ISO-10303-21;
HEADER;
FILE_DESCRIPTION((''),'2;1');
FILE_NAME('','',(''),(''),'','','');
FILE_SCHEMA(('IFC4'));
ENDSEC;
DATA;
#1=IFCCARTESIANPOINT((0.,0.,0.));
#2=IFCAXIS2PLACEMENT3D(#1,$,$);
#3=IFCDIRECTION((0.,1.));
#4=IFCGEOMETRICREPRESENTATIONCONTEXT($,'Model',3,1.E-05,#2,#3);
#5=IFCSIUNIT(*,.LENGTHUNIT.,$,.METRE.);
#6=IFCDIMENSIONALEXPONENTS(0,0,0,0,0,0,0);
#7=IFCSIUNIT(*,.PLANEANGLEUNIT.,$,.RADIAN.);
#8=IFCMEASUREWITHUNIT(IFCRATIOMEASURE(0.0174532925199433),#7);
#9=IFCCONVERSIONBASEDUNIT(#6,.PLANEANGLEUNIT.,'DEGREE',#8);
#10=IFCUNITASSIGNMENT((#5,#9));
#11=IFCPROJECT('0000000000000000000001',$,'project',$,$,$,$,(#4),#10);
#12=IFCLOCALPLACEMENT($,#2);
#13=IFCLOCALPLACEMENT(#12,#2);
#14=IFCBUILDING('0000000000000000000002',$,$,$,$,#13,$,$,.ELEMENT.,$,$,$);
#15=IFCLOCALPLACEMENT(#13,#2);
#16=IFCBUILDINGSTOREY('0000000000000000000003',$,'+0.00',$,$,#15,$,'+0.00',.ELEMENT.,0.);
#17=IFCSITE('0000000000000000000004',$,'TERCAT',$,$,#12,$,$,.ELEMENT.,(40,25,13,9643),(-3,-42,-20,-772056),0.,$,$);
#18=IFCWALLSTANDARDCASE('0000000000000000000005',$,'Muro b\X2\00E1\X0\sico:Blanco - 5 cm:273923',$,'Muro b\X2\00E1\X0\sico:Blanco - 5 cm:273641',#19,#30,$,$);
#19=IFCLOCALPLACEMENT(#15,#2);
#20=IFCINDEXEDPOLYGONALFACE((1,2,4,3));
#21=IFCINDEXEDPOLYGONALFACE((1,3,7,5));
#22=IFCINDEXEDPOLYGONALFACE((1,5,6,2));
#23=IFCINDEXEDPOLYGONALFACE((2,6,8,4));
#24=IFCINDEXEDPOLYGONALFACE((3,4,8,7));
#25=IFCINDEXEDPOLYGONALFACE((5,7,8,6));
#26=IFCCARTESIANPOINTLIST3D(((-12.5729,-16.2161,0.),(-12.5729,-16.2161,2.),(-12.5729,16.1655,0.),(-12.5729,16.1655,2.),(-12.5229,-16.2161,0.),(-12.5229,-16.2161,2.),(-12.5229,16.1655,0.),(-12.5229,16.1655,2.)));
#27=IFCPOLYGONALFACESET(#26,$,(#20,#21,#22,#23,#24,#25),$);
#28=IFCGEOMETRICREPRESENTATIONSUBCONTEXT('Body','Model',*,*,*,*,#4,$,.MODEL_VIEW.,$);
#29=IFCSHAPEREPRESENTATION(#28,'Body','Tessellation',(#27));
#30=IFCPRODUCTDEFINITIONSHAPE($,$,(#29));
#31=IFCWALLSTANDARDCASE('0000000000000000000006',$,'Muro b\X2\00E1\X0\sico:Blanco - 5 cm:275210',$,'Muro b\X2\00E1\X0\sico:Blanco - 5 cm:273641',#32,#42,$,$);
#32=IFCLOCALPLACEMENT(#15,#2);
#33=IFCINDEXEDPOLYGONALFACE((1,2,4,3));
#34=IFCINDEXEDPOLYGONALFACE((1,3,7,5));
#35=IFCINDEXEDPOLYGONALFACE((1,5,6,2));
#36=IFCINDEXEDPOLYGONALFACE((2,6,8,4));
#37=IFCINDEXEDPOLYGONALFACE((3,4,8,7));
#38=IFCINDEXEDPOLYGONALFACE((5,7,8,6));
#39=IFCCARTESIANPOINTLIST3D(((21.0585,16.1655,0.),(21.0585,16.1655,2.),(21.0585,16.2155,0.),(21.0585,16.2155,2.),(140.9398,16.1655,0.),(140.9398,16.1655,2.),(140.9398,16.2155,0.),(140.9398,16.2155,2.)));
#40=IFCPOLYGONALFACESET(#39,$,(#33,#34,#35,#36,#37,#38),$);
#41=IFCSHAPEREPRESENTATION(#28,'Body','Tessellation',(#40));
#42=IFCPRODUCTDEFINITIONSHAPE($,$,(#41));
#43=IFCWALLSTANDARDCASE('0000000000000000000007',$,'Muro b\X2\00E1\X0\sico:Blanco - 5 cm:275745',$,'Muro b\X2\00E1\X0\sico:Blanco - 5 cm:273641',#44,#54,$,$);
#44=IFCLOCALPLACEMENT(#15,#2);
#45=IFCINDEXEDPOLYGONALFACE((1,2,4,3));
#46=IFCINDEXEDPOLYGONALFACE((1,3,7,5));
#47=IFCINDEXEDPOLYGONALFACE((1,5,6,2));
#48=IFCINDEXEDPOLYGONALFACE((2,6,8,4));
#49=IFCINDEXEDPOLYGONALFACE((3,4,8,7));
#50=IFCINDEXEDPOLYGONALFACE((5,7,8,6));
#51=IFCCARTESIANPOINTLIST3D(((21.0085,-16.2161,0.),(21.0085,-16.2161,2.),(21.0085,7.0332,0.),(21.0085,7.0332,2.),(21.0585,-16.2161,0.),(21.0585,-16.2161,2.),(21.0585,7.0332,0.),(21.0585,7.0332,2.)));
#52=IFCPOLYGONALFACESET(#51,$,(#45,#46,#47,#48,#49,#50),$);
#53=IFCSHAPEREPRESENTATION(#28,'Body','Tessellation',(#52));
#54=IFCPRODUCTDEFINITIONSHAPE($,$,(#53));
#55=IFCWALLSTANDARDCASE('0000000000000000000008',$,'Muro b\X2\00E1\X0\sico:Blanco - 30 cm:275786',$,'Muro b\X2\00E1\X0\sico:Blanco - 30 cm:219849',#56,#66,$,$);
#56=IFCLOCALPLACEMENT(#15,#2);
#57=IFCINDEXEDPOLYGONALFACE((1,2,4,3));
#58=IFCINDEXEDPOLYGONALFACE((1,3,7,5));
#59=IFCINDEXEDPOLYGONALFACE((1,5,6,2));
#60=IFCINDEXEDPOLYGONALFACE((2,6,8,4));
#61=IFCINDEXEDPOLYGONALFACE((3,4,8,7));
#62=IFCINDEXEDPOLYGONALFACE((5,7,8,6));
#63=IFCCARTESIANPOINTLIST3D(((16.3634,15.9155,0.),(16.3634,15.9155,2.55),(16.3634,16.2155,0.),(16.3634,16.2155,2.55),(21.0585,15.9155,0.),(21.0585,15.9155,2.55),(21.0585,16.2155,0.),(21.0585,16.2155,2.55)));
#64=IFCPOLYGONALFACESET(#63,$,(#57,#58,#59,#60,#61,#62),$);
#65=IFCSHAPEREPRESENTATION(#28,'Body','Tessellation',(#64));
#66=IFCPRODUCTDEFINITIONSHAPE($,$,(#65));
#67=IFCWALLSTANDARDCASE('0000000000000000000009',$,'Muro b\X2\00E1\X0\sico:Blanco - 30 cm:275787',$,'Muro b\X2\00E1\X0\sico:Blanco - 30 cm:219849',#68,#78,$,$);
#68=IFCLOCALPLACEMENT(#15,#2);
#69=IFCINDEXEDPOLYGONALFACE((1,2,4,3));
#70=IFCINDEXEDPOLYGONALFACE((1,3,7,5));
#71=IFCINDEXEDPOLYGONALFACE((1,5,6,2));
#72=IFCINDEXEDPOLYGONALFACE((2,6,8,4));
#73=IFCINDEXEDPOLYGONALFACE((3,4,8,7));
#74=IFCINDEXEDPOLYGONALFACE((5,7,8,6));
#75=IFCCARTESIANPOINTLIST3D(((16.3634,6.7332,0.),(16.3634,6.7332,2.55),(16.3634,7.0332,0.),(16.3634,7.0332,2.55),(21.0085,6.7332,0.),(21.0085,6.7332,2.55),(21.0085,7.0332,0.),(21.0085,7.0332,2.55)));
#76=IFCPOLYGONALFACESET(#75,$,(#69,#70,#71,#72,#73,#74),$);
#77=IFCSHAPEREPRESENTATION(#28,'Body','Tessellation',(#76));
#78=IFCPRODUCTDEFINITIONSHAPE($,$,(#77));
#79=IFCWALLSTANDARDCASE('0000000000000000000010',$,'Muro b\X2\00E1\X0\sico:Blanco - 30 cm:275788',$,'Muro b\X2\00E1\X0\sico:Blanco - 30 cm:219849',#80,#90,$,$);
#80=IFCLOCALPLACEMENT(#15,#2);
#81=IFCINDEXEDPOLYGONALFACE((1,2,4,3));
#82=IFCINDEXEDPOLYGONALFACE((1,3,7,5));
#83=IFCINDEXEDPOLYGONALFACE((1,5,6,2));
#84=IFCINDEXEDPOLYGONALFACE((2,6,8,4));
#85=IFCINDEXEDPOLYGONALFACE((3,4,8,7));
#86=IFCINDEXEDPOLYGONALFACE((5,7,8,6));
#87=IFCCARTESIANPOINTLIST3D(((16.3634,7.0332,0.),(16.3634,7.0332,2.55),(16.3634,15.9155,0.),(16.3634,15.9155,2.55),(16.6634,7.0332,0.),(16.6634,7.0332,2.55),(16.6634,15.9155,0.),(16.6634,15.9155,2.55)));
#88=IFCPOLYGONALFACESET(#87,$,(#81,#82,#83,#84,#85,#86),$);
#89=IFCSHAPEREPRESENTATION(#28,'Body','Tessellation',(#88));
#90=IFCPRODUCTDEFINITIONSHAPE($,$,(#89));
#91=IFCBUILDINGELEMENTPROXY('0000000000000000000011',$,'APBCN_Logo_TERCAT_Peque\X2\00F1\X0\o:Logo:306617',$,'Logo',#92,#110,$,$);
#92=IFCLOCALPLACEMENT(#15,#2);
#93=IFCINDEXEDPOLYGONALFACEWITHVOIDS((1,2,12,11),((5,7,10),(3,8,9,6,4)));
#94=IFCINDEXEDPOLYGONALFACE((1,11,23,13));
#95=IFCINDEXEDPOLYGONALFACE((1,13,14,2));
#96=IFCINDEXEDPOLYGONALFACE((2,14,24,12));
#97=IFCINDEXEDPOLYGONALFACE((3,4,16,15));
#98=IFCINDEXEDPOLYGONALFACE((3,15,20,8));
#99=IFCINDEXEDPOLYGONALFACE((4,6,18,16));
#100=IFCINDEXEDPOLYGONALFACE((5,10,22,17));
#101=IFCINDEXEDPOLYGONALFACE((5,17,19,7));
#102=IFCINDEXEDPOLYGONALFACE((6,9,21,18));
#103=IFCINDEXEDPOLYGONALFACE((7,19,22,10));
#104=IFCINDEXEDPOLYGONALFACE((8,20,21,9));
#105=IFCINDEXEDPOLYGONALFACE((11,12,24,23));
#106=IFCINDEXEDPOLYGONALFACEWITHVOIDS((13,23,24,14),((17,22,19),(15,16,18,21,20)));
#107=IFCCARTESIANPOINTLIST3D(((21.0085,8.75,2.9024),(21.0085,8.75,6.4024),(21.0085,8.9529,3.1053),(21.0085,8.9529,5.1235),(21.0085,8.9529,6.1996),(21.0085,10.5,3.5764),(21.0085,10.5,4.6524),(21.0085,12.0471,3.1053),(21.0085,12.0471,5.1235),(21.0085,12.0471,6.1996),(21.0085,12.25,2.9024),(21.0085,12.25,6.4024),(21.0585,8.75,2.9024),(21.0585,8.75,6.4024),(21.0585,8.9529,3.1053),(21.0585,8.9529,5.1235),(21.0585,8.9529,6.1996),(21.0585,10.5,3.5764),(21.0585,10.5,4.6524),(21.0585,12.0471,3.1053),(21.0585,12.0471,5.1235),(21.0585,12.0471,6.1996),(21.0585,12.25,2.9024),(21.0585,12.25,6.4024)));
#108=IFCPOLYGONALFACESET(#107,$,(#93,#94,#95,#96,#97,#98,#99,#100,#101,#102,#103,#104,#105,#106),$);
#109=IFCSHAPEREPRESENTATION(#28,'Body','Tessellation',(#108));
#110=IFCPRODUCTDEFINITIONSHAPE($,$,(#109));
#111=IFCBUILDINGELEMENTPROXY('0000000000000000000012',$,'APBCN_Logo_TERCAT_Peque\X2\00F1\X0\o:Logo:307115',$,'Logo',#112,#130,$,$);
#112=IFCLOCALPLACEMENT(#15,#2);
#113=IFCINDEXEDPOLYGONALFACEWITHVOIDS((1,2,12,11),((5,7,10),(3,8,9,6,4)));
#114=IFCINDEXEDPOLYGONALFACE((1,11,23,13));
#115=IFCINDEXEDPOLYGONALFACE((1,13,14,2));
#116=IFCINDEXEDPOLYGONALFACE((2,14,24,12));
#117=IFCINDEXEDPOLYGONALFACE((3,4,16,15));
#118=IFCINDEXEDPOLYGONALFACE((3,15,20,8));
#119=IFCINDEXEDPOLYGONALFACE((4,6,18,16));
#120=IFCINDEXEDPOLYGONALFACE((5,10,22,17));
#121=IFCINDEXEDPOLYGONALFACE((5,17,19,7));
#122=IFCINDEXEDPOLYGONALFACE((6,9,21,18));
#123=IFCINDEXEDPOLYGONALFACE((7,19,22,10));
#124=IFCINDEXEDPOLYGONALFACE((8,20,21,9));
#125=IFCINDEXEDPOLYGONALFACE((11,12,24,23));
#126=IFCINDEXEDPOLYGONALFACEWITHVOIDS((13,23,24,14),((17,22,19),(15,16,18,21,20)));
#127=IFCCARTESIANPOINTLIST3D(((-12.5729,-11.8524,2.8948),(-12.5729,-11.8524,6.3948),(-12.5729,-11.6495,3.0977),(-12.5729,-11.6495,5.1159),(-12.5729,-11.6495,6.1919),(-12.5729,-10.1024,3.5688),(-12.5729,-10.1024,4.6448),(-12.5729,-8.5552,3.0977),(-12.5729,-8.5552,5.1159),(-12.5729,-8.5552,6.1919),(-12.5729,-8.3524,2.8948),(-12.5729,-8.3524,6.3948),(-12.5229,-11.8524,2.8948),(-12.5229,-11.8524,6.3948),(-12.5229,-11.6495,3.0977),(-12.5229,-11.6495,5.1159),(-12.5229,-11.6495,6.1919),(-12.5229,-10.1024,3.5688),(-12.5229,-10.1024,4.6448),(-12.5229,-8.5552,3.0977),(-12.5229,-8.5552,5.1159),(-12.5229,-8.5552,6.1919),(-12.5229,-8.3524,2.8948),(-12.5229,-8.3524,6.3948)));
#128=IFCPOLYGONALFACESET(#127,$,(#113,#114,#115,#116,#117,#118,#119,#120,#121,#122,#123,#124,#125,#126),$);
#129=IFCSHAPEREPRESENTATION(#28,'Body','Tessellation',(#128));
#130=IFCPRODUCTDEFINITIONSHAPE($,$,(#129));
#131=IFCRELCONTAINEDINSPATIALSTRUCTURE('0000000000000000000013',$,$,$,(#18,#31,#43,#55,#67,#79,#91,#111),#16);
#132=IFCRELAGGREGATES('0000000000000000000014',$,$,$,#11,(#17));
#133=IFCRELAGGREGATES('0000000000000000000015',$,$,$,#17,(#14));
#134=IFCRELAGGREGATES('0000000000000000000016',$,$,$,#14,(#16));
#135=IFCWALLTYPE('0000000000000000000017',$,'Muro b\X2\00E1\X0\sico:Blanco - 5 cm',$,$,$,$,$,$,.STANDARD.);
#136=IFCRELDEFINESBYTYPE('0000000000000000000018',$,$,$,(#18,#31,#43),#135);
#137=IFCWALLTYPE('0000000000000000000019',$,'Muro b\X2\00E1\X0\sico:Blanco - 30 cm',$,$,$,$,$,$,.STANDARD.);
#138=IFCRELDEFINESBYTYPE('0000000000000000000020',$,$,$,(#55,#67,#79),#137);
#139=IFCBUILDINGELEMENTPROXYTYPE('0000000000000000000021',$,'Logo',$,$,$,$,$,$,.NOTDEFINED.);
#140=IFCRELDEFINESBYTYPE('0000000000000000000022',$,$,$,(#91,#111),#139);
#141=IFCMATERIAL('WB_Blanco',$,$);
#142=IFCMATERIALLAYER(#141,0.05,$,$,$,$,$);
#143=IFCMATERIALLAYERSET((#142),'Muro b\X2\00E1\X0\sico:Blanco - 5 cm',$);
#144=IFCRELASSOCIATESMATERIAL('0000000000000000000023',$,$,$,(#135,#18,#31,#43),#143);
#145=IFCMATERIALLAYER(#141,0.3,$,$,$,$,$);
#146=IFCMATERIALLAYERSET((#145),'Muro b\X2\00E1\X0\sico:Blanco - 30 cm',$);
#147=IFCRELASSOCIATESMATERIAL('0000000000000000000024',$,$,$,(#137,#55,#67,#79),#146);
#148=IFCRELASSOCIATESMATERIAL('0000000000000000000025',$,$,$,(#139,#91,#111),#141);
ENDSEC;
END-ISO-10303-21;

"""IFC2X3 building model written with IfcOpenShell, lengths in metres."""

from ifc_helpers import new_model, entity, si_unit, converted_unit, direction, frame, frame_2d, origin, place, context, subcontext, project, spatial, polyline, rectangle, outline, extrude, clip, bounded_halfspace, source, transform, mapped, material, layer, layer_set, layer_usage, type_object, type_shapes, element, save


model = new_model("IFC2X3")

# Units and contexts
model_context = context("Model", 3, precision=1e-05, world=origin(), true_north=direction((0.0, 1.0)))
body_context = subcontext(model_context, "Body", "Model", "MODEL_VIEW")
ifc_project = project(units=[si_unit("LENGTHUNIT", "METRE"), converted_unit("PLANEANGLEUNIT", "DEGREE", entity("IfcRatioMeasure", 0.0174532925199433), si_unit("PLANEANGLEUNIT", "RADIAN"), dimensions=[0, 0, 0, 0, 0, 0, 0])], contexts=[model_context])

# Site, building, storey
site_placement = place(None, origin())
site = spatial("IfcSite", under=ifc_project, at=site_placement, Name="TERCAT", CompositionType="ELEMENT", RefLatitude=(40, 25, 13, 9643), RefLongitude=(-3, -42, -20, -772056), RefElevation=0.0)
building_placement = place(site_placement, origin())
building = spatial("IfcBuilding", under=site, at=building_placement, CompositionType="ELEMENT")
storey_placement = place(building_placement, origin())
storey = spatial("IfcBuildingStorey", under=building, at=storey_placement, Name="+0.00", LongName="+0.00", CompositionType="ELEMENT", Elevation=0.0)

# Walls
ifc_material_1 = material(Name="WB_Blanco")
ifc_layer_1 = layer(ifc_material_1, 0.05)
ifc_layer_set_1 = layer_set([ifc_layer_1], Name="Muro básico:Blanco - 5 cm")
ifc_layer_usage_1 = layer_usage(ifc_layer_set_1, "AXIS2", "POSITIVE", -0.025)
wall_type_1 = type_object("IfcWallType", Name="Muro básico:Blanco - 5 cm", PredefinedType="STANDARD", material=ifc_layer_set_1)
wall_1_placement = place(storey_placement, frame((-12.5479, 16.1655, 0.0), z_axis=(0.0, 0.0, 1.0), x_axis=(0.0, -1.0, 0.0)))
element("IfcWallStandardCase", 1, at=wall_1_placement, inside=storey, type_object=wall_type_1, material=ifc_layer_usage_1, Name="Muro básico:Blanco - 5 cm:273923", ObjectType="Muro básico:Blanco - 5 cm:273641", context=body_context, shape_type="SweptSolid", body=[
    extrude(rectangle(XDim=32.3816, YDim=0.05, at=frame_2d((16.1908, 0.0), x_axis=(-1.0, 0.0))), origin(), (0.0, 0.0, 1.0), 2.0),
])
ifc_layer_usage_2 = layer_usage(ifc_layer_set_1, "AXIS2", "POSITIVE", -0.025)
wall_2_placement = place(storey_placement, frame((21.0585, 16.1905, 0.0)))
element("IfcWallStandardCase", 2, at=wall_2_placement, inside=storey, type_object=wall_type_1, material=ifc_layer_usage_2, Name="Muro básico:Blanco - 5 cm:275210", ObjectType="Muro básico:Blanco - 5 cm:273641", context=body_context, shape_type="SweptSolid", body=[
    extrude(rectangle(XDim=119.8813, YDim=0.05, at=frame_2d((59.9407, 0.0), x_axis=(-1.0, 0.0))), origin(), (0.0, 0.0, 1.0), 2.0),
])
ifc_layer_usage_3 = layer_usage(ifc_layer_set_1, "AXIS2", "POSITIVE", -0.025)
wall_3_placement = place(storey_placement, frame((21.0335, -16.2161, 0.0), z_axis=(0.0, 0.0, 1.0), x_axis=(0.0, 1.0, 0.0)))
element("IfcWallStandardCase", 3, at=wall_3_placement, inside=storey, type_object=wall_type_1, material=ifc_layer_usage_3, Name="Muro básico:Blanco - 5 cm:275745", ObjectType="Muro básico:Blanco - 5 cm:273641", context=body_context, shape_type="SweptSolid", body=[
    extrude(rectangle(XDim=23.2493, YDim=0.05, at=frame_2d((11.6247, 0.0), x_axis=(-1.0, 0.0))), origin(), (0.0, 0.0, 1.0), 2.0),
])
ifc_layer_2 = layer(ifc_material_1, 0.3)
ifc_layer_set_2 = layer_set([ifc_layer_2], Name="Muro básico:Blanco - 30 cm")
ifc_layer_usage_4 = layer_usage(ifc_layer_set_2, "AXIS2", "POSITIVE", -0.15)
wall_type_2 = type_object("IfcWallType", Name="Muro básico:Blanco - 30 cm", PredefinedType="STANDARD", material=ifc_layer_set_2)
wall_4_placement = place(storey_placement, frame((21.0585, 16.0655, 0.0), z_axis=(0.0, 0.0, 1.0), x_axis=(-1.0, 0.0, 0.0)))
element("IfcWallStandardCase", 4, at=wall_4_placement, inside=storey, type_object=wall_type_2, material=ifc_layer_usage_4, Name="Muro básico:Blanco - 30 cm:275786", ObjectType="Muro básico:Blanco - 30 cm:219849", context=body_context, shape_type="Clipping", body=[
    clip(extrude(rectangle(XDim=4.6951, YDim=0.3, at=frame_2d((2.3476, 0.0), x_axis=(-1.0, 0.0))), origin(), (0.0, 0.0, 1.0), 2.55), bounded_halfspace(frame((0.0, -0.15, 2.55), z_axis=(0.0, 0.0, 1.0), x_axis=(-1.0, 0.0, 0.0)), False, frame((0.0, -0.15, 2.55), z_axis=(0.0, 0.0, 1.0), x_axis=(-1.0, 0.0, 0.0)), polyline([(0.0, 0.0), (-4.6951, 0.0), (-4.6951, -0.3), (-4.3951, -0.3), (0.0, -0.3), (0.0, 0.0)]))),
])
ifc_layer_usage_5 = layer_usage(ifc_layer_set_2, "AXIS2", "POSITIVE", -0.15)
wall_5_placement = place(storey_placement, frame((16.3634, 6.8832, 0.0)))
element("IfcWallStandardCase", 5, at=wall_5_placement, inside=storey, type_object=wall_type_2, material=ifc_layer_usage_5, Name="Muro básico:Blanco - 30 cm:275787", ObjectType="Muro básico:Blanco - 30 cm:219849", context=body_context, shape_type="Clipping", body=[
    clip(extrude(rectangle(XDim=4.6451, YDim=0.3, at=frame_2d((2.3226, 0.0), x_axis=(-1.0, 0.0))), origin(), (0.0, 0.0, 1.0), 2.55), bounded_halfspace(frame((0.0, -0.15, 2.55)), False, frame((0.0, -0.15, 2.55)), polyline([(0.0, 0.0), (4.6451, 0.0), (4.6451, 0.3), (0.3, 0.3), (0.0, 0.3), (0.0, 0.0)]))),
])
ifc_layer_usage_6 = layer_usage(ifc_layer_set_2, "AXIS2", "POSITIVE", -0.15)
wall_6_placement = place(storey_placement, frame((16.5134, 15.9155, 0.0), z_axis=(0.0, 0.0, 1.0), x_axis=(0.0, -1.0, 0.0)))
element("IfcWallStandardCase", 6, at=wall_6_placement, inside=storey, type_object=wall_type_2, material=ifc_layer_usage_6, Name="Muro básico:Blanco - 30 cm:275788", ObjectType="Muro básico:Blanco - 30 cm:219849", context=body_context, shape_type="Clipping", body=[
    clip(extrude(rectangle(XDim=8.8822, YDim=0.3, at=frame_2d((4.4411, 0.0), x_axis=(-1.0, 0.0))), origin(), (0.0, 0.0, 1.0), 2.55), bounded_halfspace(frame((0.0, -0.15, 2.55), z_axis=(0.0, 0.0, 1.0), x_axis=(0.0, 1.0, 0.0)), False, frame((0.0, -0.15, 2.55), z_axis=(0.0, 0.0, 1.0), x_axis=(0.0, 1.0, 0.0)), polyline([(0.0, 0.0), (0.0, -8.8822), (0.3, -8.8822), (0.3, 0.0), (0.0, 0.0)]))),
])

# Building element proxies
building_element_proxy_type_1 = type_object("IfcBuildingElementProxyType", Name="Logo", PredefinedType="NOTDEFINED", material=ifc_material_1)
shared_shape_1 = source(origin(), body_context, "Body", "SweptSolid", [
    extrude(outline(polyline([(-1.75, -1.75), (1.75, -1.75), (1.75, 1.75), (-1.75, 1.75), (-1.75, -1.75)]), holes=[polyline([(1.5471, -0.4711), (0.0, 1.076), (-1.5471, -0.4711), (-1.5471, 1.5471), (1.5471, 1.5471), (1.5471, -0.4711)]), polyline([(-1.5471, -1.5471), (0.0, 0.0), (1.5471, -1.5471), (-1.5471, -1.5471)])]), frame((0.0, 0.0, 0.0), z_axis=(0.0, 0.0, 1.0), x_axis=(-1.0, 0.0, 0.0)), (0.0, 0.0, 1.0), 0.05),
])
type_shapes(building_element_proxy_type_1, [shared_shape_1])
for number, where, z_axis, x_axis, name in (
    (7, (21.0585, 10.5, 4.6524), (-1.0, 0.0, 0.0), (0.0, -1.0, 0.0), "APBCN_Logo_TERCAT_Pequeño:Logo:306617"),
    (8, (-12.5729, -10.1024, 4.6448), (1.0, 0.0, 0.0), (0.0, 1.0, 0.0), "APBCN_Logo_TERCAT_Pequeño:Logo:307115"),
):
    element("IfcBuildingElementProxy", number, at=place(storey_placement, frame(where, z_axis=z_axis, x_axis=x_axis)), inside=storey, type_object=building_element_proxy_type_1, material=ifc_material_1, Name=name, ObjectType="Logo", context=body_context, shape_type="MappedRepresentation", body=[
        mapped(shared_shape_1, transform((0.0, 0.0, 0.0), scale=1.0)),
    ])

save(model, "model.ifc")
